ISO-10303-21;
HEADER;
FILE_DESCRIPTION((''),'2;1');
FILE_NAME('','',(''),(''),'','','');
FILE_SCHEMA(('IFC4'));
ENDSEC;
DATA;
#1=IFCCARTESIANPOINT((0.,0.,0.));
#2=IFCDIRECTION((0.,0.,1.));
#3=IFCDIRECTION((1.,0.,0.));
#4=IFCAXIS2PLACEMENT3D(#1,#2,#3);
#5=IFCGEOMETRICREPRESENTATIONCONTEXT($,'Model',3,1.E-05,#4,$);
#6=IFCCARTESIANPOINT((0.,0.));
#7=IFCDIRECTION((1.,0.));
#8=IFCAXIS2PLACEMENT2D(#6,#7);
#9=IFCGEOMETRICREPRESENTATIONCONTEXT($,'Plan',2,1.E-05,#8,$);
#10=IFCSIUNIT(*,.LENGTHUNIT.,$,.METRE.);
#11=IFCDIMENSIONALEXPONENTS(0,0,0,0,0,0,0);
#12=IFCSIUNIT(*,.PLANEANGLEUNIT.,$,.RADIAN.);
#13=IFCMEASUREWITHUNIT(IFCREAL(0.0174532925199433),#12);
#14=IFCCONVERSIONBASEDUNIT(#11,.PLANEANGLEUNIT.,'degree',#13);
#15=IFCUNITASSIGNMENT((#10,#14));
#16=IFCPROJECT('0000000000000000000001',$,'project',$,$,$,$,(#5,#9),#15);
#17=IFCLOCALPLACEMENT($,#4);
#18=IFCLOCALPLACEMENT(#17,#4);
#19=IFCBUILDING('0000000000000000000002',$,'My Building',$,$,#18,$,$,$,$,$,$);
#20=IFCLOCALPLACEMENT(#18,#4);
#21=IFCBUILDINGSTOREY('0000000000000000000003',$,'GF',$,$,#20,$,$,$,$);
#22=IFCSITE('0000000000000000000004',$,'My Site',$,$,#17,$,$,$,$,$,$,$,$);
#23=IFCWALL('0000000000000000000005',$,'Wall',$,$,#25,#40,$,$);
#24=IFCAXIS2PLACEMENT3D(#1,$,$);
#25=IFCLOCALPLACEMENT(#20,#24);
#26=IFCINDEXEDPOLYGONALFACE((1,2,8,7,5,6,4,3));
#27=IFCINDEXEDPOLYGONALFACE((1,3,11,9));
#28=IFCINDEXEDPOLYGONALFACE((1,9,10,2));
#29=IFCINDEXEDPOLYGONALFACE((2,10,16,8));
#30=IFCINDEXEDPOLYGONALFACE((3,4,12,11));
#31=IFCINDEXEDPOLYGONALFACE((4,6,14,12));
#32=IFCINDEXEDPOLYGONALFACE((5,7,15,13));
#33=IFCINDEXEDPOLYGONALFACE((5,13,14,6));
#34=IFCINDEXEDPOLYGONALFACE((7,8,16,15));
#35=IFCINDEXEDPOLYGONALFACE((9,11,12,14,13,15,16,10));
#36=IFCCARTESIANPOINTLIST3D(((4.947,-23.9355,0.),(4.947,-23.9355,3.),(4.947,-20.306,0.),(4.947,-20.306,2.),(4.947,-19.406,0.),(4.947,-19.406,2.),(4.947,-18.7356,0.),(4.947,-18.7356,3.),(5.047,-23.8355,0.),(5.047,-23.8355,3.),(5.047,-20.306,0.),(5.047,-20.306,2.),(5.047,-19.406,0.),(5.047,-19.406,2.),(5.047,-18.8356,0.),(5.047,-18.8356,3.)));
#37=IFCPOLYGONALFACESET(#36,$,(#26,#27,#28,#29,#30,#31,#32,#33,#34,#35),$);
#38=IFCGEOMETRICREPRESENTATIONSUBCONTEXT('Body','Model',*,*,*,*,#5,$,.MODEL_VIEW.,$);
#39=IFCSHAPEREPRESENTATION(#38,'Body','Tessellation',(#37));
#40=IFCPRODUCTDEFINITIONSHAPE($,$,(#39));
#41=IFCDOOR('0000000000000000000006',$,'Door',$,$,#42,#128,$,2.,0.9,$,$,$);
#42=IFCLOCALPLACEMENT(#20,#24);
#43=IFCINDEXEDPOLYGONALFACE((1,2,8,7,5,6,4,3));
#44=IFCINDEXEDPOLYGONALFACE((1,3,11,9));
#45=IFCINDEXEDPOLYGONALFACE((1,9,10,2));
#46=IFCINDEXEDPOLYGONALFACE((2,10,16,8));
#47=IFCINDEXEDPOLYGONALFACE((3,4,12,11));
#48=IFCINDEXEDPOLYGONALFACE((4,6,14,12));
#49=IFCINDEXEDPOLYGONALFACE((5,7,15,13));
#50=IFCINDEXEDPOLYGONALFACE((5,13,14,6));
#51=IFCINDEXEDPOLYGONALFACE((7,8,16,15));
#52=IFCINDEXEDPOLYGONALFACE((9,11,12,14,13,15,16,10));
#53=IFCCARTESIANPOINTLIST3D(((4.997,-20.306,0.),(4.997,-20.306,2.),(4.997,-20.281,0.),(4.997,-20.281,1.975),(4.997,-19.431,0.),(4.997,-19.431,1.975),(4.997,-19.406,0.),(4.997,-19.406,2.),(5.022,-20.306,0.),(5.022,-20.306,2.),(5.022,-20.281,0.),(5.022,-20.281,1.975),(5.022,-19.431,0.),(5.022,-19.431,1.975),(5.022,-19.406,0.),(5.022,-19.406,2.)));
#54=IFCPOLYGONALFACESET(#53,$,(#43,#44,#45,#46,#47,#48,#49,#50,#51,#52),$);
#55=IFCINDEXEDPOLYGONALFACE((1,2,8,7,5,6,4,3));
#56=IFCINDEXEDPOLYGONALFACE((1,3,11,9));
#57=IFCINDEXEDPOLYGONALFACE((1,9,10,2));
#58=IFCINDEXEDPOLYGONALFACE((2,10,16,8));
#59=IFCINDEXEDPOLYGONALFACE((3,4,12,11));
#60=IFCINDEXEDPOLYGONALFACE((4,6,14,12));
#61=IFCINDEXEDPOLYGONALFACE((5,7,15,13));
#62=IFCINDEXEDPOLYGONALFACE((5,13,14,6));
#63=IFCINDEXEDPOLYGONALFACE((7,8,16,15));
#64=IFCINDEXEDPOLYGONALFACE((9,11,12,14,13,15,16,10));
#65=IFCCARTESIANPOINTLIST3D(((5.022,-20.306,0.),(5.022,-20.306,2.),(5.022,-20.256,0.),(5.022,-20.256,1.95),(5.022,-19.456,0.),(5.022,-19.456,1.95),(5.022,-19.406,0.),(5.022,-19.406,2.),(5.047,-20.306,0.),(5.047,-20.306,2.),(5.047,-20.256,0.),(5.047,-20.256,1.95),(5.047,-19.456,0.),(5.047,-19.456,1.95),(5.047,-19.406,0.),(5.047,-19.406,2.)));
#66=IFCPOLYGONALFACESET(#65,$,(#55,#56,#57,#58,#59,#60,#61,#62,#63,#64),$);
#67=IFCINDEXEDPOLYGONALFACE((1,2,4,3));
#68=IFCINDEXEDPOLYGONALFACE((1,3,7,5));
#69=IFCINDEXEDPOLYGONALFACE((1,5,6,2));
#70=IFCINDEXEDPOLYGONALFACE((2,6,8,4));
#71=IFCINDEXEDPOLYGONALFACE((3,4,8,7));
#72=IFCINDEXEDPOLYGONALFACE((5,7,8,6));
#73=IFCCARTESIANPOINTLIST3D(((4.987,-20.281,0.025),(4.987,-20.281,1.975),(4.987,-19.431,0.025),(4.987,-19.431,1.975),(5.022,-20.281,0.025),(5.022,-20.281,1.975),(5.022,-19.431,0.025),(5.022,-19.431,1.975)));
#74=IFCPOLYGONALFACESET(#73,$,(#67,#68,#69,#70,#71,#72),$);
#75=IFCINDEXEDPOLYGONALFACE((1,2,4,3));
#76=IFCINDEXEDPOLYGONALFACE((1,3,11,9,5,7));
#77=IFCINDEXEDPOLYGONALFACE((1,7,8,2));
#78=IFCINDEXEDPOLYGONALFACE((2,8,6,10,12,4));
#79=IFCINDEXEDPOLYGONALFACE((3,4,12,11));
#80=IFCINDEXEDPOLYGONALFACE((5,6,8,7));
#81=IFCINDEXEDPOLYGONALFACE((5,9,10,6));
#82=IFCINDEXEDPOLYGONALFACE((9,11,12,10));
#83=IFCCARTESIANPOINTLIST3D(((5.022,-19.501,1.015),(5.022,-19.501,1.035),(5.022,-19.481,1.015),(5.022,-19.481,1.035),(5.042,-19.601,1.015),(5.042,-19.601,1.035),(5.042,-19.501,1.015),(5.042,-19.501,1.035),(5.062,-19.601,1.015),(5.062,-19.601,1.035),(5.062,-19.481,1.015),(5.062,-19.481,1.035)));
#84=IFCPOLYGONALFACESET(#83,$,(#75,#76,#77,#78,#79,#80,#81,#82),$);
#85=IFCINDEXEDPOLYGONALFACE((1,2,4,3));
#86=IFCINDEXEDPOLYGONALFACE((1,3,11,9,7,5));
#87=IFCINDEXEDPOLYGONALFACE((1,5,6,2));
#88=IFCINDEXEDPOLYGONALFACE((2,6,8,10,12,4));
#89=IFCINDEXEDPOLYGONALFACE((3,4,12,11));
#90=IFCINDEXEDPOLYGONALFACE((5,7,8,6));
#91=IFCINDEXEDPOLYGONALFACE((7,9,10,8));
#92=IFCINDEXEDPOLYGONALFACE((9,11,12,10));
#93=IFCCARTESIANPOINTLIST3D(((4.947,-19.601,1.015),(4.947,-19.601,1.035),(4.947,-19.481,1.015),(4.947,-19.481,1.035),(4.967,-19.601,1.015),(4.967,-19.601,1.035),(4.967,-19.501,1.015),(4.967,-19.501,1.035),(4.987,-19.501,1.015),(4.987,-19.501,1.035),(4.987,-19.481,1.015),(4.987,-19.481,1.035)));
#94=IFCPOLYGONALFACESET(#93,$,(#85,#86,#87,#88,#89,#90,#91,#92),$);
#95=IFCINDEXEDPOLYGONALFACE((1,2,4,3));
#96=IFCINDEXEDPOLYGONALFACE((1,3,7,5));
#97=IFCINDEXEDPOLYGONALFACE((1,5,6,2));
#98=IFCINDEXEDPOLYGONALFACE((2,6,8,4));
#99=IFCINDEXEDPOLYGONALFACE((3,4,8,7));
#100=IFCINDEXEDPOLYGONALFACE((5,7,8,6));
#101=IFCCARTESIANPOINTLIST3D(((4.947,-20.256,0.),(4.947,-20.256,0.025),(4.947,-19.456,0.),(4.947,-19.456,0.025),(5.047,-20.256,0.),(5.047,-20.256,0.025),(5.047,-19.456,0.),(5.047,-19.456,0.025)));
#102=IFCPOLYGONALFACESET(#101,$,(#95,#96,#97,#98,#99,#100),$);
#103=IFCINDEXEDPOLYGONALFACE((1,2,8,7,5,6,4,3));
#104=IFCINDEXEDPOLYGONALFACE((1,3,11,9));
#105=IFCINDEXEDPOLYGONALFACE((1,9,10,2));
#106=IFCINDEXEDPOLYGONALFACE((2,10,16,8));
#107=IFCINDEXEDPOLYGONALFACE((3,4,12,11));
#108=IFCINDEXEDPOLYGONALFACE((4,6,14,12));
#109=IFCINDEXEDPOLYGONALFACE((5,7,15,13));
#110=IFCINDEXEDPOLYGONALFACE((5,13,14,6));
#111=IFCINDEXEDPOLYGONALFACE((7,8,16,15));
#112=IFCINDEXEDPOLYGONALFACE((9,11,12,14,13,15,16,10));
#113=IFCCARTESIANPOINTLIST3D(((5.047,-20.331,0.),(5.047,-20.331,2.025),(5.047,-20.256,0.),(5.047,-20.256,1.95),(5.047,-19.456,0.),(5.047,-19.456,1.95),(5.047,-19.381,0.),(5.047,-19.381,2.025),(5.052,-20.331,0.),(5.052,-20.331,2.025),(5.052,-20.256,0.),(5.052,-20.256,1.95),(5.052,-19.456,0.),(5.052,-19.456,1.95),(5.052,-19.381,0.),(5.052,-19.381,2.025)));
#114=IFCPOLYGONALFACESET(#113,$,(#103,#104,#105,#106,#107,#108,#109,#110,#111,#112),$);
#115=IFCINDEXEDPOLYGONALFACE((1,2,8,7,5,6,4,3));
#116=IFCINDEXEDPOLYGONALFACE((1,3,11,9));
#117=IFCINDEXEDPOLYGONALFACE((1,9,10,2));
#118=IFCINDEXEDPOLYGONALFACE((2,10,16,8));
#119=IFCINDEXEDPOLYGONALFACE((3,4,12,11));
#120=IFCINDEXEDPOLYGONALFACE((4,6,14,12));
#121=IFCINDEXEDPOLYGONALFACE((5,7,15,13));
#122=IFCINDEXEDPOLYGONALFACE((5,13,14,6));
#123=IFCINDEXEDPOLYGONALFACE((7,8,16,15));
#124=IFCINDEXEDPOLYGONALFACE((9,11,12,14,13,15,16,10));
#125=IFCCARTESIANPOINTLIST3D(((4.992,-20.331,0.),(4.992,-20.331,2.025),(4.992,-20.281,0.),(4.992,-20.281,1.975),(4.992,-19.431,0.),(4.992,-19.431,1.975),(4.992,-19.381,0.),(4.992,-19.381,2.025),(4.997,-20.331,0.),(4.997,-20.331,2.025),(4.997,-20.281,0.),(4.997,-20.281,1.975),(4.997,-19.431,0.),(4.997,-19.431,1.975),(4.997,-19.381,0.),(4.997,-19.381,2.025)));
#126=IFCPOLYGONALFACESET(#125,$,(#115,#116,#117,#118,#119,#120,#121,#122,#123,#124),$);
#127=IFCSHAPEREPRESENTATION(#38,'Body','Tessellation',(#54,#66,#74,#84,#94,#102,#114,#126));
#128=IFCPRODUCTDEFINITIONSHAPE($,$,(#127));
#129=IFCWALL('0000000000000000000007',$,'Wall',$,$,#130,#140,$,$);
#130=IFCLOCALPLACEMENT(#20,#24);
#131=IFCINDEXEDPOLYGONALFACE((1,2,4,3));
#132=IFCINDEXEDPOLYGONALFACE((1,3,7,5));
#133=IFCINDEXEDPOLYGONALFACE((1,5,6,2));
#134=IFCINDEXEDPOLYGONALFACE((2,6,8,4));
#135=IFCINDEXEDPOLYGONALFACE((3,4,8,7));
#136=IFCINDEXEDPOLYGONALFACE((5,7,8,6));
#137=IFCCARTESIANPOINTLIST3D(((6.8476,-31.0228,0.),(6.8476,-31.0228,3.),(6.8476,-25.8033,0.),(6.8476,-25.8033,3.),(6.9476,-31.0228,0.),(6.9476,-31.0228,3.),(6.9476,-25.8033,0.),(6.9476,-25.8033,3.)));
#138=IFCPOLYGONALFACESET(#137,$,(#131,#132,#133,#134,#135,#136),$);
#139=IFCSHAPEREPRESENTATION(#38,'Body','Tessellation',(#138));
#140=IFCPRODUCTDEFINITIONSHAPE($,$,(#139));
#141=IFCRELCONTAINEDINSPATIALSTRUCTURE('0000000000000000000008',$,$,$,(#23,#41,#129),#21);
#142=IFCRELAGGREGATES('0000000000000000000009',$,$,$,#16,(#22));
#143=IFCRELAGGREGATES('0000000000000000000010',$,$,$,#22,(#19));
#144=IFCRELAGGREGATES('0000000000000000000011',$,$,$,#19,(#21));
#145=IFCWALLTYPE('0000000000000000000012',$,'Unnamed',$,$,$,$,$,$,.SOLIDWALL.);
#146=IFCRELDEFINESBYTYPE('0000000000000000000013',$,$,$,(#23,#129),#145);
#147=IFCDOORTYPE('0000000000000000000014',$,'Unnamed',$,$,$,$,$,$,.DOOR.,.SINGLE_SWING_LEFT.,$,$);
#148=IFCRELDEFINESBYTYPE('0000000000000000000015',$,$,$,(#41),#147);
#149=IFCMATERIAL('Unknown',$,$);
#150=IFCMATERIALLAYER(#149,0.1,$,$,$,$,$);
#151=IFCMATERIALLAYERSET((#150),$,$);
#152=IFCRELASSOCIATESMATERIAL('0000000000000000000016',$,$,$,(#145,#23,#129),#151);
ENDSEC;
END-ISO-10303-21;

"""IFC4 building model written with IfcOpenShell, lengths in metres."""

from ifc_helpers import new_model, entity, si_unit, converted_unit, frame, origin_with_axes, origin_2d_with_axis, place, context, subcontext, project, spatial, line, indexed_curve, outline, extrude, shape, source, transform, mapped, material, layer, layer_set, layer_usage, type_object, type_shapes, element, fill, save


model = new_model("IFC4")

# Units and contexts
model_context = context("Model", 3, precision=1e-05, world=origin_with_axes())
plan_context = context("Plan", 2, precision=1e-05, world=origin_2d_with_axis())
body_context_1 = subcontext(model_context, "Body", "Model", "MODEL_VIEW")
body_context_2 = subcontext(plan_context, "Body", "Plan", "PLAN_VIEW")
ifc_project = project(units=[si_unit("LENGTHUNIT", "METRE"), converted_unit("PLANEANGLEUNIT", "degree", entity("IfcReal", 0.0174532925199433), si_unit("PLANEANGLEUNIT", "RADIAN"), dimensions=[0, 0, 0, 0, 0, 0, 0])], contexts=[model_context, plan_context])

# Site, building, storey
site_placement = place(None, origin_with_axes())
site = spatial("IfcSite", under=ifc_project, at=site_placement, Name="My Site")
building_placement = place(site_placement, origin_with_axes())
building = spatial("IfcBuilding", under=site, at=building_placement, Name="My Building")
storey_placement = place(building_placement, origin_with_axes())
storey = spatial("IfcBuildingStorey", under=building, at=storey_placement, Name="GF")

# Shared definitions
ifc_material = material(Name="Unknown")

# Shared definitions
ifc_layer_1 = layer(ifc_material, 0.1)
ifc_layer_set_1 = layer_set([ifc_layer_1])
wall_type = type_object("IfcWallType", Name="Unnamed", PredefinedType="SOLIDWALL", material=ifc_layer_set_1)

# Shared definitions
shared_shape_1 = source(origin_with_axes(), body_context_1, "Body", "SweptSolid", [
    extrude(outline(indexed_curve([(0.0, 0.0), (0.9, 0.0), (0.9, 2.0), (0.0, 2.0)], segments=[line(1, 2, 3, 4, 1)])), frame((0.0, -0.6, 0.0), z_axis=(0.0, -1.0, 0.0), x_axis=(1.0, 0.0, 0.0)), (0.0, 0.0, -1.0), 1.2),
])
door_type = type_object("IfcDoorType", Name="Unnamed", OperationType="SINGLE_SWING_LEFT", PredefinedType="DOOR")
shared_shape_2 = source(origin_with_axes(), body_context_1, "Body", "SweptSolid", [
    extrude(outline(indexed_curve([(0.0, 0.0), (0.0, 2.0), (0.9, 2.0), (0.9, 0.0), (0.875, 0.0), (0.875, 1.975), (0.025, 1.975), (0.025, 0.0)], segments=[line(1, 2, 3, 4, 5, 6, 7, 8, 1)])), frame((0.0, 0.025, 0.0), z_axis=(0.0, -1.0, 0.0), x_axis=(1.0, 0.0, 0.0)), (0.0, 0.0, -1.0), 0.025),
    extrude(outline(indexed_curve([(0.0, 0.0), (0.0, 2.0), (0.9, 2.0), (0.9, 0.0), (0.85, 0.0), (0.85, 1.95), (0.05, 1.95), (0.05, 0.0)], segments=[line(1, 2, 3, 4, 5, 6, 7, 8, 1)])), frame((0.0, 0.0, 0.0), z_axis=(0.0, -1.0, 0.0), x_axis=(1.0, 0.0, 0.0)), (0.0, 0.0, -1.0), 0.025),
    extrude(outline(indexed_curve([(0.0, 0.0), (0.85, 0.0), (0.85, 0.035), (0.0, 0.035)], segments=[line(1, 2, 3, 4, 1)])), frame((0.025, 0.025, 0.025), z_axis=(0.0, 0.0, 1.0), x_axis=(1.0, 0.0, 0.0)), (0.0, 0.0, 1.0), 1.95),
    extrude(outline(indexed_curve([(0.0, 0.0), (0.0, -0.04), (-0.12, -0.04), (-0.12, -0.02), (-0.02, -0.02), (-0.02, 0.0)], segments=[line(1, 2, 3, 4, 5, 6, 1)])), frame((0.825, 0.025, 1.015), z_axis=(0.0, 0.0, 1.0), x_axis=(1.0, 0.0, 0.0)), (0.0, 0.0, 1.0), 0.02),
    extrude(outline(indexed_curve([(0.0, 0.0), (0.0, 0.04), (-0.12, 0.04), (-0.12, 0.02), (-0.02, 0.02), (-0.02, 0.0)], segments=[line(1, 2, 3, 4, 5, 6, 1)])), frame((0.825, 0.06, 1.015), z_axis=(0.0, 0.0, 1.0), x_axis=(1.0, 0.0, 0.0)), (0.0, 0.0, 1.0), 0.02),
    extrude(outline(indexed_curve([(0.0, 0.0), (0.8, 0.0), (0.8, 0.1), (0.0, 0.1)], segments=[line(1, 2, 3, 4, 1)])), frame((0.05, 0.0, 0.0), z_axis=(0.0, 0.0, 1.0), x_axis=(1.0, 0.0, 0.0)), (0.0, 0.0, 1.0), 0.025),
    extrude(outline(indexed_curve([(0.0, 0.0), (0.0, 2.025), (0.95, 2.025), (0.95, 0.0), (0.875, 0.0), (0.875, 1.95), (0.075, 1.95), (0.075, 0.0)], segments=[line(1, 2, 3, 4, 5, 6, 7, 8, 1)])), frame((-0.025, -0.005, 0.0), z_axis=(0.0, -1.0, 0.0), x_axis=(1.0, 0.0, 0.0)), (0.0, 0.0, -1.0), 0.005),
    extrude(outline(indexed_curve([(0.0, 0.0), (0.0, 2.025), (0.95, 2.025), (0.95, 0.0), (0.9, 0.0), (0.9, 1.975), (0.05, 1.975), (0.05, 0.0)], segments=[line(1, 2, 3, 4, 5, 6, 7, 8, 1)])), frame((-0.025, 0.05, 0.0), z_axis=(0.0, -1.0, 0.0), x_axis=(1.0, 0.0, 0.0)), (0.0, 0.0, -1.0), 0.005),
])
shared_shape_3 = source(origin_with_axes(), body_context_2, "Body", "Curve2D", [
    entity("IfcIndexedPolyCurve", entity("IfcCartesianPointList2D", [[0.0, 0.0], [0.0, 0.05], [0.025, 0.05], [0.025, 0.025], [0.05, 0.025], [0.05, 0.0]]), [entity("IfcLineIndex", [1, 2, 3, 4, 5, 6, 1])]),
    entity("IfcIndexedPolyCurve", entity("IfcCartesianPointList2D", [[0.9, 0.0], [0.9, 0.05], [0.875, 0.05], [0.875, 0.025], [0.85, 0.025], [0.85, 0.0]]), [entity("IfcLineIndex", [1, 2, 3, 4, 5, 6, 1])]),
    entity("IfcTrimmedCurve", entity("IfcEllipse", entity("IfcAxis2Placement2D", entity("IfcCartesianPoint", [0.06, 0.05]), entity("IfcDirection", [1.0, 0.0])), 0.815, 0.85), [entity("IfcCartesianPoint", [0.875, 0.05])], [entity("IfcCartesianPoint", [0.06, 0.9])], True, "CARTESIAN"),
    entity("IfcIndexedPolyCurve", entity("IfcCartesianPointList2D", [[0.025, 0.05], [0.06, 0.05], [0.06, 0.9], [0.025, 0.9]]), [entity("IfcLineIndex", [1, 2, 3, 4, 1])]),
])
type_shapes(door_type, [shared_shape_2, shared_shape_3])

# Wall, opening, door
ifc_layer_usage_1 = layer_usage(ifc_layer_set_1, "AXIS2", "POSITIVE", 0.0)
wall_1_placement = place(storey_placement, frame((5.047, -23.8355, 0.0), z_axis=(0.0, 0.0, 1.0), x_axis=(0.0, 1.0, 0.0)))
wall_1 = element("IfcWall", 1, at=wall_1_placement, inside=storey, type_object=wall_type, material=ifc_layer_usage_1, Name="Wall", context=body_context_1, shape_type="SweptSolid", body=[
    extrude(outline(indexed_curve([(0.0, 0.0), (-0.1, 0.1), (5.1, 0.1), (5.0, 0.0)], segments=[line(1, 2, 3, 4, 1)])), origin_with_axes(), (0.0, 0.0, 1.0), 3.0),
])
opening_1_placement = place(wall_1_placement, frame((3.5295, 0.0, 0.0), z_axis=(0.0, 0.0, 1.0), x_axis=(1.0, 0.0, 0.0)))
opening_1 = element("IfcOpeningElement", 2, at=opening_1_placement, cuts=wall_1, PredefinedType="OPENING", context=body_context_1, shape_type="MappedRepresentation", body=[
    mapped(shared_shape_1, transform((0.0, 0.0, 0.0), x_axis=(1.0, 0.0, 0.0), y_axis=(0.0, 1.0, 0.0), z_axis=(0.0, 0.0, 1.0), scale=1.0)),
])
door_1_placement = place(opening_1_placement, frame((0.0, 0.0, 0.0), z_axis=(0.0, 0.0, 1.0), x_axis=(1.0, 0.0, 0.0)))
door_1 = element("IfcDoor", 3, at=door_1_placement, inside=storey, type_object=door_type, Name="Door", OverallHeight=2.0, OverallWidth=0.9, shapes=[
    shape(body_context_1, "Body", "MappedRepresentation", [mapped(shared_shape_2, transform((0.0, 0.0, 0.0), x_axis=(1.0, 0.0, 0.0), y_axis=(0.0, 1.0, 0.0), z_axis=(0.0, 0.0, 1.0), scale=1.0))]),
    shape(body_context_2, "Body", "MappedRepresentation", [mapped(shared_shape_3, transform((0.0, 0.0, 0.0), x_axis=(1.0, 0.0, 0.0), y_axis=(0.0, 1.0, 0.0), z_axis=(0.0, 0.0, 1.0), scale=1.0))]),
])
fill(opening_1, door_1)

# Wall
ifc_layer_usage_2 = layer_usage(ifc_layer_set_1, "AXIS2", "POSITIVE", 0.0)
wall_2_placement = place(storey_placement, frame((6.8476, -25.8033, 0.0), z_axis=(0.0, 0.0, 1.0), x_axis=(0.0, -1.0, 0.0)))
element("IfcWall", 4, at=wall_2_placement, inside=storey, type_object=wall_type, material=ifc_layer_usage_2, Name="Wall", context=body_context_1, shape_type="SweptSolid", body=[
    extrude(outline(indexed_curve([(0.0, 0.0), (0.0, 0.1), (5.2195, 0.1), (5.2195, 0.0)], segments=[line(1, 2, 3, 4, 1)])), origin_with_axes(), (0.0, 0.0, 1.0), 3.0),
])

save(model, "model.ifc")
